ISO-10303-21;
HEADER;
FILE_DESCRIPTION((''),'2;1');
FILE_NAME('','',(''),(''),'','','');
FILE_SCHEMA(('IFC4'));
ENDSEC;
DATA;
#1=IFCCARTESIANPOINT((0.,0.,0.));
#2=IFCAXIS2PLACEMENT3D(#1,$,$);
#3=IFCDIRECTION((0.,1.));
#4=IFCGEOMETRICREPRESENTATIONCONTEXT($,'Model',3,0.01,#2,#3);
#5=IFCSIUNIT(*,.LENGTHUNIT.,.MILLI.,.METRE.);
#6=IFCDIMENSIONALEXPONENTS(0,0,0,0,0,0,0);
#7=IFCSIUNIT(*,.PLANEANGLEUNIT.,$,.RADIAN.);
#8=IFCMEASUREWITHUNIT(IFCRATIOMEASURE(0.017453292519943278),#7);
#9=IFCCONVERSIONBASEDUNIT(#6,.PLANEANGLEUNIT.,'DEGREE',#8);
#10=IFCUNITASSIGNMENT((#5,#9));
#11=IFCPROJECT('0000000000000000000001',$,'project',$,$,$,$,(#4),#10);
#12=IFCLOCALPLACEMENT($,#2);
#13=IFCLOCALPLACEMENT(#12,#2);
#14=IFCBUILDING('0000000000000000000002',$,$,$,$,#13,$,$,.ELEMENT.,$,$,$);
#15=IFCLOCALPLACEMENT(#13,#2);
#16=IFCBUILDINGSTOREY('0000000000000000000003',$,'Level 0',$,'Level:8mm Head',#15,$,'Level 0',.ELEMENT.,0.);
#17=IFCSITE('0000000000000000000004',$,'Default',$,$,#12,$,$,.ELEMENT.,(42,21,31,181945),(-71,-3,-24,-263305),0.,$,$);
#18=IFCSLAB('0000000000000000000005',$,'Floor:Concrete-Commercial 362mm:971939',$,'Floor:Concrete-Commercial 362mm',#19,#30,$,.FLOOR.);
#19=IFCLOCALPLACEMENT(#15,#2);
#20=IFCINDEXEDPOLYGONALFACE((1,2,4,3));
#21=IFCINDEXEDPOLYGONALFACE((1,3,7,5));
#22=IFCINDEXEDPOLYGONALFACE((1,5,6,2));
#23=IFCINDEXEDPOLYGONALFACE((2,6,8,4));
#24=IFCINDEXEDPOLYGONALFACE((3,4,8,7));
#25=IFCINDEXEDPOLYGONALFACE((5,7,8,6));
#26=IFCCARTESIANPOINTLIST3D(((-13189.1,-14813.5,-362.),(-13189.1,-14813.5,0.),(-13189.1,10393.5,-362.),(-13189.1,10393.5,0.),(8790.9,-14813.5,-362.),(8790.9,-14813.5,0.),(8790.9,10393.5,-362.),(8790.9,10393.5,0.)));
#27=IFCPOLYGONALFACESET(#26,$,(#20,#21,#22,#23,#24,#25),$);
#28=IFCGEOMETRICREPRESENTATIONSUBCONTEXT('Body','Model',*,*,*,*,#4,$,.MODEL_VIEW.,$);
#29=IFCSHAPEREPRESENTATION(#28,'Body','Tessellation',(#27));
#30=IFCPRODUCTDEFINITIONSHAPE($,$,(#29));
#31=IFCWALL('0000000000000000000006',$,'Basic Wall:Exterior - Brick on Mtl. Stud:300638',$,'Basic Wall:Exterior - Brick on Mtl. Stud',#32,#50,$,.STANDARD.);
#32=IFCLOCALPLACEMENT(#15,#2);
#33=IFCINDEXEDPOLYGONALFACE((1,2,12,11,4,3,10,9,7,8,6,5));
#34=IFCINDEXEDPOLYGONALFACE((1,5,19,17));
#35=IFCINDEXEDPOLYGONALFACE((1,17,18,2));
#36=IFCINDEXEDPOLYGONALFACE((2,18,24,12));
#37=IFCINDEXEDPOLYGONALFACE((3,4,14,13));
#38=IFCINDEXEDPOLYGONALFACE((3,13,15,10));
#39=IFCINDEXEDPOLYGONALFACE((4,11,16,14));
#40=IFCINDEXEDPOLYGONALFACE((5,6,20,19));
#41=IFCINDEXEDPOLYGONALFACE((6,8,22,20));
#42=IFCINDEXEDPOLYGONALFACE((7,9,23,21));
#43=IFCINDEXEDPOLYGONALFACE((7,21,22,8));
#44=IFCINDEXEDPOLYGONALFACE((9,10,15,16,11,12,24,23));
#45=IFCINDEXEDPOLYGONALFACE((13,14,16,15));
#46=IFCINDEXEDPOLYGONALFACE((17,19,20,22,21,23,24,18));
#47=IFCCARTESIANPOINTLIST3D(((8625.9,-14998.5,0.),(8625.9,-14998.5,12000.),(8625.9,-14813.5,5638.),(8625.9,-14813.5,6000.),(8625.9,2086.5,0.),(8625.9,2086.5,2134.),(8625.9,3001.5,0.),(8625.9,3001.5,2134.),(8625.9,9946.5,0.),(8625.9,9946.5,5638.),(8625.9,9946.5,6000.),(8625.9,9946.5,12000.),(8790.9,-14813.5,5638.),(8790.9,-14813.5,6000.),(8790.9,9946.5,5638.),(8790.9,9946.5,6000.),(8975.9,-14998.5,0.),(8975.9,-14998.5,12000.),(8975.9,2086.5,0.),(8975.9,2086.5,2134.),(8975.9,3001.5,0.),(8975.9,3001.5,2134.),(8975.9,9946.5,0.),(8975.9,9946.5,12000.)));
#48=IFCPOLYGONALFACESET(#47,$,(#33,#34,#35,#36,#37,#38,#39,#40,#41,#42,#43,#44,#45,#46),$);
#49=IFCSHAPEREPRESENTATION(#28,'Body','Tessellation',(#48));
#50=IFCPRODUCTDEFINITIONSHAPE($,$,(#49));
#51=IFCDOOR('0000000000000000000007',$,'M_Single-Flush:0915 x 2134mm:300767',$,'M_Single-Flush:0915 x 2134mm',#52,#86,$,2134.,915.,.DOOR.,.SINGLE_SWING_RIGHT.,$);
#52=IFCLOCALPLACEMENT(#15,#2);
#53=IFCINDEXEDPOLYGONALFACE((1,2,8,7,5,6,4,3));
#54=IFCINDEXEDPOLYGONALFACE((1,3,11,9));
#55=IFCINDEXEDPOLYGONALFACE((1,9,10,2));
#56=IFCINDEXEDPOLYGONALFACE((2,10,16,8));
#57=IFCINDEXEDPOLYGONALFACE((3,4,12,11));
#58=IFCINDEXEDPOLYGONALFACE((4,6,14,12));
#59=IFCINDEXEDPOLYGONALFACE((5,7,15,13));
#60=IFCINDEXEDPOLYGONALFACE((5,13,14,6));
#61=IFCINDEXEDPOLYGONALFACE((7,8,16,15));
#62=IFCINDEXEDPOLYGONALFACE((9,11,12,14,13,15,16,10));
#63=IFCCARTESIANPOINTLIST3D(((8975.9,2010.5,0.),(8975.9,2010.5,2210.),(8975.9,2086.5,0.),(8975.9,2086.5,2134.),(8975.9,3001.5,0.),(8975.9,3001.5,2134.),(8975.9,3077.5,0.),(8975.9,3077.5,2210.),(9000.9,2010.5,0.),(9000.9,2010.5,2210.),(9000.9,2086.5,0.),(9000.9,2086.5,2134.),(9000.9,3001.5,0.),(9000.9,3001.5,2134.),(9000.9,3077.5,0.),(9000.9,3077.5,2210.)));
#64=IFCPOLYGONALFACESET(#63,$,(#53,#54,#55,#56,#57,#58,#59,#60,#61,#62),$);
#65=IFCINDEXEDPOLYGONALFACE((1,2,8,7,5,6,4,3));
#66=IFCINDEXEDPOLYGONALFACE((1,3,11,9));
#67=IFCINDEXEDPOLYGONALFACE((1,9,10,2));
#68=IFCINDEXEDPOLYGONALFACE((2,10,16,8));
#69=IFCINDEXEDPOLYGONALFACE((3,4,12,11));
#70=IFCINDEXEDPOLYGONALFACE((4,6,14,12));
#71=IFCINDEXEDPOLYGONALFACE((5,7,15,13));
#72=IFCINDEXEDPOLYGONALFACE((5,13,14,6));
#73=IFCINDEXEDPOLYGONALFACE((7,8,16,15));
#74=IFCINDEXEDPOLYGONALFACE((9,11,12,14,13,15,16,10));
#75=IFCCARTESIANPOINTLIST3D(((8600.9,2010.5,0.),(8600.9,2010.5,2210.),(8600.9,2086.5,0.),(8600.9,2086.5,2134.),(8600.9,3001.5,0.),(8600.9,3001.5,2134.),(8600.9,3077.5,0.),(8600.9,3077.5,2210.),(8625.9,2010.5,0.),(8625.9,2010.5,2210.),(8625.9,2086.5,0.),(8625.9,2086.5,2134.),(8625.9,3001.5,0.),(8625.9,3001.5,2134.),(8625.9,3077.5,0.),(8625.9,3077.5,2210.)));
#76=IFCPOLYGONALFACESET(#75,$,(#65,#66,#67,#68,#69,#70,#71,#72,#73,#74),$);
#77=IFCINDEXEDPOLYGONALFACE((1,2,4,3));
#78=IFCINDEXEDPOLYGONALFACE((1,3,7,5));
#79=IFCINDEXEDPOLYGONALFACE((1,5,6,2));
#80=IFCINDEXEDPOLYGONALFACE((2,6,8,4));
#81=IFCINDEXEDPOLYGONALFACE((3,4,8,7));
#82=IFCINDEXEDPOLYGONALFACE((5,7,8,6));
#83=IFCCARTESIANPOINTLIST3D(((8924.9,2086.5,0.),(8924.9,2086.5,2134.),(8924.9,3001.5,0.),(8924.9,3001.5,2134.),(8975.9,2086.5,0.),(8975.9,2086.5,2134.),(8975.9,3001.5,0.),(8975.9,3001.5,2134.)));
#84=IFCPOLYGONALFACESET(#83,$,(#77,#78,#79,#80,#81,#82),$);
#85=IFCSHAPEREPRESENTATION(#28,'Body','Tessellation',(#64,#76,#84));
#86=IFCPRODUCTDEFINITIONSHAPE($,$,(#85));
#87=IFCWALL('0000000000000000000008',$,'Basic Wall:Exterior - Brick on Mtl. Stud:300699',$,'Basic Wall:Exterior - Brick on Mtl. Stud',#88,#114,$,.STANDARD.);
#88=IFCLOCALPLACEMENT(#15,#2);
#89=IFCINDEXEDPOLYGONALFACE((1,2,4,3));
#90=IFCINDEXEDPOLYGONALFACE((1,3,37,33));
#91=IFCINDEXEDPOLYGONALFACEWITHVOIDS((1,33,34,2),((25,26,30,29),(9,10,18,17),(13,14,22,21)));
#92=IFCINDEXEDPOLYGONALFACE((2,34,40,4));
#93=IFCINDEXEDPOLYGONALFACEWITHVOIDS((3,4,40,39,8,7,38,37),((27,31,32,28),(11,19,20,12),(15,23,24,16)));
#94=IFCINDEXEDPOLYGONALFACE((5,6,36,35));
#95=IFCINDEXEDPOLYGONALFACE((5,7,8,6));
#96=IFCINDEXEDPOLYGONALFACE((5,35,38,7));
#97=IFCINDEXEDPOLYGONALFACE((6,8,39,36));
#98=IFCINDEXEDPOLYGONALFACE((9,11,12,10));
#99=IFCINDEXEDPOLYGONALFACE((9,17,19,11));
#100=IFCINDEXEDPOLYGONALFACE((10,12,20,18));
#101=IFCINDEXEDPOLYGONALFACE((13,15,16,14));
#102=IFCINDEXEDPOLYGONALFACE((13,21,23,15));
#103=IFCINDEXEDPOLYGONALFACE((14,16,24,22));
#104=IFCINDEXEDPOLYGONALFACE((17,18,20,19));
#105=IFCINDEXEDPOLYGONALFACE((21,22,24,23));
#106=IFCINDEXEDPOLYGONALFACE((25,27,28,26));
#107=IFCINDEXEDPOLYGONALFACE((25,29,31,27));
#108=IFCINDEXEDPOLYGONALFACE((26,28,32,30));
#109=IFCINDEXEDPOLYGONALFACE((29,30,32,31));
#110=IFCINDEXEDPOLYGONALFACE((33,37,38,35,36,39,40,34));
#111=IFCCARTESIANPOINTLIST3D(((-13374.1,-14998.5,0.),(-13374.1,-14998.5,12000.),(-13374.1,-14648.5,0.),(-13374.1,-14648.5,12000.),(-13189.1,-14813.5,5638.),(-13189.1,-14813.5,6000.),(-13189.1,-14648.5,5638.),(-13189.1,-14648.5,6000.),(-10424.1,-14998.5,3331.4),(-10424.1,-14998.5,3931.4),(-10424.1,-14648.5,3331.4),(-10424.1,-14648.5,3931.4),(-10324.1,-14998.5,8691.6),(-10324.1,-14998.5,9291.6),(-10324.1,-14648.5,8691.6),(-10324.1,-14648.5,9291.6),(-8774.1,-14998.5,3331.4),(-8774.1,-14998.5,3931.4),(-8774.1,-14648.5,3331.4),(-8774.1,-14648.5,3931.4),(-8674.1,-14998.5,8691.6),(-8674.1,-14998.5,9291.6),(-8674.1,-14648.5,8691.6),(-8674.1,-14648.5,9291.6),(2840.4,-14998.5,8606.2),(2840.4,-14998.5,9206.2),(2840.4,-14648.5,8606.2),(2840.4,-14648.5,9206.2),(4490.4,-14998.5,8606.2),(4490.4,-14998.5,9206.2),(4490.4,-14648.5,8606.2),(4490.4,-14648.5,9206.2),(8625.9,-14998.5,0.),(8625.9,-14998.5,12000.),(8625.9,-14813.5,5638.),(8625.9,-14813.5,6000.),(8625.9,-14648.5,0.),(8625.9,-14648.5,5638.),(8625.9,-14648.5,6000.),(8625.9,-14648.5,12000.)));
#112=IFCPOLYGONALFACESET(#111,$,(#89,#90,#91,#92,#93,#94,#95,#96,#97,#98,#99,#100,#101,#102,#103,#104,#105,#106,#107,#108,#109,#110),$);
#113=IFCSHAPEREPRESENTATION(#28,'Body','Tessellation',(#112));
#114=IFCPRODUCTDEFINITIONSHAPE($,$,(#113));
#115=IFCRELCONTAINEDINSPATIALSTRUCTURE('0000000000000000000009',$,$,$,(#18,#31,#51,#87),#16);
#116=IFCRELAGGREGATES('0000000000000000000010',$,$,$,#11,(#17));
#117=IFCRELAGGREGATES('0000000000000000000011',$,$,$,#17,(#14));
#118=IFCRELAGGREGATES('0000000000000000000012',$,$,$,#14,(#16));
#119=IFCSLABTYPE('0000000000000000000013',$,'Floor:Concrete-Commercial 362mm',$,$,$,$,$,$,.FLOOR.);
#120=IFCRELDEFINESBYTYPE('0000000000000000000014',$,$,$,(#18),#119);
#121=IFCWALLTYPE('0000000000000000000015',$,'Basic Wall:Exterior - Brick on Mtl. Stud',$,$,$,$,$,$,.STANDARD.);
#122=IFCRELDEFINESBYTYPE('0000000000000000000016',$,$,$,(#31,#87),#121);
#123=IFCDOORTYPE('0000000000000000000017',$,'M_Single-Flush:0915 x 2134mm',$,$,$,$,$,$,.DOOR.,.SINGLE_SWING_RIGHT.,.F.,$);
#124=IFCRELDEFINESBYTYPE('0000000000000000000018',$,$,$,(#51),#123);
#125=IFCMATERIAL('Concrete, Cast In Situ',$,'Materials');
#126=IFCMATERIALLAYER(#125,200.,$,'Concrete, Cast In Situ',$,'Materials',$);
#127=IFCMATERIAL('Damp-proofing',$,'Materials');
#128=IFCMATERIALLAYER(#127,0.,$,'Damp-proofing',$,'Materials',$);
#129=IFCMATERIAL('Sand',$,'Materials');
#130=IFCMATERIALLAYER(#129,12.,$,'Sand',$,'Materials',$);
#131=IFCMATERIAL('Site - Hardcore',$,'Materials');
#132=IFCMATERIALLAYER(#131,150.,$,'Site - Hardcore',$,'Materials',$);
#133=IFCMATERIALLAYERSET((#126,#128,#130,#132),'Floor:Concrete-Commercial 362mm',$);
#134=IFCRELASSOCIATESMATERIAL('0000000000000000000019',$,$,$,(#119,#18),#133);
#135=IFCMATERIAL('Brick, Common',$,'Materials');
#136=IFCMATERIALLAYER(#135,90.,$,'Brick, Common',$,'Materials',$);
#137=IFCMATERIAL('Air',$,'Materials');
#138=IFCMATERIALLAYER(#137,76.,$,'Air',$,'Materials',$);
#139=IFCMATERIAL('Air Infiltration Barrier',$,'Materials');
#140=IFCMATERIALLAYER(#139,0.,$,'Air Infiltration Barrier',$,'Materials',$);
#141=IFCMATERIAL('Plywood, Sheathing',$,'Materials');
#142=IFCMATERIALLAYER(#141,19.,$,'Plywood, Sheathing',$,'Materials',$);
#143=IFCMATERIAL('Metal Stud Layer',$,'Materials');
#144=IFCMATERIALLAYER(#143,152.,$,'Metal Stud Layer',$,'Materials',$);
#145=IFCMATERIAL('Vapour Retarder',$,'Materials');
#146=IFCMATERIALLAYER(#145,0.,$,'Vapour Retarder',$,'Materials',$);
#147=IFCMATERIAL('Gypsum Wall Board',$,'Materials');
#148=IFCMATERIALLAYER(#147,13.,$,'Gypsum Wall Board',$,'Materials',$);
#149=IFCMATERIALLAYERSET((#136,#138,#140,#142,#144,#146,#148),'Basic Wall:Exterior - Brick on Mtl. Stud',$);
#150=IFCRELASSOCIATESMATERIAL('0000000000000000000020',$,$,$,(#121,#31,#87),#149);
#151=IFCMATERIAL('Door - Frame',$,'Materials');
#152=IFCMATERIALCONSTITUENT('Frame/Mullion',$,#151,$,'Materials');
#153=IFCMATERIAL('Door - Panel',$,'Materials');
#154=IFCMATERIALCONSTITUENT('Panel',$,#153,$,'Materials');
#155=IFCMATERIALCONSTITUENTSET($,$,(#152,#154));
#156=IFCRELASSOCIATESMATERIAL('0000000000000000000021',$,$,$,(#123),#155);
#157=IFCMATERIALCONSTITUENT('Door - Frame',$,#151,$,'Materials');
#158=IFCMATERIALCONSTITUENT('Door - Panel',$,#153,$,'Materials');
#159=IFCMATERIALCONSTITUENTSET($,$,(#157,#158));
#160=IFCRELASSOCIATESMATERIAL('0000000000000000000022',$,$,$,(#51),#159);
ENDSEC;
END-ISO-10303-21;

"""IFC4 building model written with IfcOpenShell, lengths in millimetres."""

from ifc_helpers import new_model, entity, si_unit, converted_unit, direction, frame, frame_2d, origin, place, context, subcontext, project, spatial, polyline, rectangle, outline, extrude, source, transform, mapped, material, layer, layer_set, layer_usage, constituent, constituent_set, type_object, type_shapes, element, fill, save


model = new_model("IFC4")

# Units and contexts
model_context = context("Model", 3, precision=0.01, world=origin(), true_north=direction((0.0, 1.0)))
body_context = subcontext(model_context, "Body", "Model", "MODEL_VIEW")
ifc_project = project(units=[si_unit("LENGTHUNIT", "METRE", prefix="MILLI"), converted_unit("PLANEANGLEUNIT", "DEGREE", entity("IfcRatioMeasure", 0.017453292519943278), si_unit("PLANEANGLEUNIT", "RADIAN"), dimensions=[0, 0, 0, 0, 0, 0, 0])], contexts=[model_context])

# Site, building, storey
site_placement = place(None, origin())
site = spatial("IfcSite", under=ifc_project, at=site_placement, Name="Default", CompositionType="ELEMENT", RefLatitude=(42, 21, 31, 181945), RefLongitude=(-71, -3, -24, -263305), RefElevation=0.0)
building_placement = place(site_placement, origin())
building = spatial("IfcBuilding", under=site, at=building_placement, CompositionType="ELEMENT")
storey_placement = place(building_placement, origin())
storey = spatial("IfcBuildingStorey", under=building, at=storey_placement, Name="Level 0", ObjectType="Level:8mm Head", LongName="Level 0", CompositionType="ELEMENT", Elevation=0.0)

# Slab
ifc_material_1 = material(Name="Concrete, Cast In Situ", Category="Materials")
ifc_layer_1 = layer(ifc_material_1, 200.0, Name="Concrete, Cast In Situ", Category="Materials")
ifc_material_2 = material(Name="Damp-proofing", Category="Materials")
ifc_layer_2 = layer(ifc_material_2, 0.0, Name="Damp-proofing", Category="Materials")
ifc_material_3 = material(Name="Sand", Category="Materials")
ifc_layer_3 = layer(ifc_material_3, 12.0, Name="Sand", Category="Materials")
ifc_material_4 = material(Name="Site - Hardcore", Category="Materials")
ifc_layer_4 = layer(ifc_material_4, 150.0, Name="Site - Hardcore", Category="Materials")
ifc_layer_set_1 = layer_set([ifc_layer_1, ifc_layer_2, ifc_layer_3, ifc_layer_4], Name="Floor:Concrete-Commercial 362mm")
ifc_layer_usage_1 = layer_usage(ifc_layer_set_1, "AXIS3", "POSITIVE", 0.0)
slab_type = type_object("IfcSlabType", Name="Floor:Concrete-Commercial 362mm", PredefinedType="FLOOR", material=ifc_layer_set_1)
slab_placement = place(storey_placement, origin())
element("IfcSlab", 1, at=slab_placement, inside=storey, type_object=slab_type, material=ifc_layer_usage_1, Name="Floor:Concrete-Commercial 362mm:971939", ObjectType="Floor:Concrete-Commercial 362mm", PredefinedType="FLOOR", context=body_context, shape_type="SweptSolid", body=[
    extrude(rectangle(XDim=25207.0, YDim=21980.0, at=frame_2d((0.0, 0.0), x_axis=(1.0, 0.0))), frame((-2199.1, -2210.0, 0.0), z_axis=(0.0, 0.0, -1.0), x_axis=(0.0, 1.0, 0.0)), (0.0, 0.0, 1.0), 362.0),
])

# Wall, openings, door
ifc_material_5 = material(Name="Brick, Common", Category="Materials")
ifc_layer_5 = layer(ifc_material_5, 90.0, Name="Brick, Common", Category="Materials")
ifc_material_6 = material(Name="Air", Category="Materials")
ifc_layer_6 = layer(ifc_material_6, 76.0, Name="Air", Category="Materials")
ifc_material_7 = material(Name="Air Infiltration Barrier", Category="Materials")
ifc_layer_7 = layer(ifc_material_7, 0.0, Name="Air Infiltration Barrier", Category="Materials")
ifc_material_8 = material(Name="Plywood, Sheathing", Category="Materials")
ifc_layer_8 = layer(ifc_material_8, 19.0, Name="Plywood, Sheathing", Category="Materials")
ifc_material_9 = material(Name="Metal Stud Layer", Category="Materials")
ifc_layer_9 = layer(ifc_material_9, 152.0, Name="Metal Stud Layer", Category="Materials")
ifc_material_10 = material(Name="Vapour Retarder", Category="Materials")
ifc_layer_10 = layer(ifc_material_10, 0.0, Name="Vapour Retarder", Category="Materials")
ifc_material_11 = material(Name="Gypsum Wall Board", Category="Materials")
ifc_layer_11 = layer(ifc_material_11, 13.0, Name="Gypsum Wall Board", Category="Materials")
ifc_layer_set_2 = layer_set([ifc_layer_5, ifc_layer_6, ifc_layer_7, ifc_layer_8, ifc_layer_9, ifc_layer_10, ifc_layer_11], Name="Basic Wall:Exterior - Brick on Mtl. Stud")
ifc_layer_usage_2 = layer_usage(ifc_layer_set_2, "AXIS2", "NEGATIVE", 175.0)
wall_type_1 = type_object("IfcWallType", Name="Basic Wall:Exterior - Brick on Mtl. Stud", PredefinedType="STANDARD", material=ifc_layer_set_2)
wall_1_placement = place(storey_placement, frame((8800.9, 9946.5, 0.0), z_axis=(0.0, 0.0, 1.0), x_axis=(0.0, -1.0, 0.0)))
wall_1 = element("IfcWall", 2, at=wall_1_placement, inside=storey, type_object=wall_type_1, material=ifc_layer_usage_2, Name="Basic Wall:Exterior - Brick on Mtl. Stud:300638", ObjectType="Basic Wall:Exterior - Brick on Mtl. Stud", PredefinedType="STANDARD", context=body_context, shape_type="SweptSolid", body=[
    extrude(rectangle(XDim=24945.0, YDim=350.0, at=frame_2d((12472.5, 0.0), x_axis=(-1.0, 0.0))), origin(), (0.0, 0.0, 1.0), 12000.0),
])
opening_1_placement = place(storey_placement, frame((8800.9, 9946.5, 0.0), z_axis=(0.0, 0.0, 1.0), x_axis=(0.0, -1.0, 0.0)))
element("IfcOpeningElement", 3, at=opening_1_placement, cuts=wall_1, PredefinedType="OPENING", context=body_context, shape_type="SweptSolid", body=[
    extrude(rectangle(XDim=165.0, YDim=24760.0, at=frame_2d((16.5, 2443.0), x_axis=(1.0, 0.0))), frame((14823.0, -109.0, 5638.0), z_axis=(0.0, 0.0, 1.0), x_axis=(0.0, 1.0, 0.0)), (0.0, 0.0, 1.0), 362.0),
])
opening_2_placement = place(wall_1_placement, frame((6945.0, -175.0, 0.0)))
opening_2 = element("IfcOpeningElement", 4, at=opening_2_placement, cuts=wall_1, PredefinedType="OPENING", context=body_context, shape_type="SweptSolid", body=[
    extrude(rectangle(XDim=915.0, YDim=2134.0, at=frame_2d((1067.0, 457.5), x_axis=(0.0, 1.0))), frame((0.0, 0.0, 0.0), z_axis=(0.0, 1.0, 0.0), x_axis=(0.0, 0.0, 1.0)), (0.0, 0.0, 1.0), 350.0),
])
ifc_material_12 = material(Name="Door - Frame", Category="Materials")
ifc_constituent_1 = constituent(ifc_material_12, Name="Door - Frame", Category="Materials")
ifc_material_13 = material(Name="Door - Panel", Category="Materials")
ifc_constituent_2 = constituent(ifc_material_13, Name="Door - Panel", Category="Materials")
ifc_constituent_set_1 = constituent_set(constituents=[ifc_constituent_1, ifc_constituent_2])
ifc_constituent_3 = constituent(ifc_material_12, Name="Frame/Mullion", Category="Materials")
ifc_constituent_4 = constituent(ifc_material_13, Name="Panel", Category="Materials")
ifc_constituent_set_2 = constituent_set(constituents=[ifc_constituent_3, ifc_constituent_4])
door_type_1 = type_object("IfcDoorType", Name="M_Single-Flush:0915 x 2134mm", OperationType="SINGLE_SWING_RIGHT", ParameterTakesPrecedence=False, PredefinedType="DOOR", material=ifc_constituent_set_2)
shared_shape_1 = source(origin(), body_context, "Body", "SweptSolid", [
    extrude(outline(polyline([(-533.5, -1124.0), (533.5, -1124.0), (533.5, 1086.0), (457.5, 1086.0), (457.5, -1048.0), (-457.5, -1048.0), (-457.5, 1086.0), (-533.5, 1086.0), (-533.5, -1124.0)])), frame((457.5, 350.0, 1086.0), z_axis=(0.0, 1.0, 0.0), x_axis=(1.0, 0.0, 0.0)), (0.0, 0.0, 1.0), 25.0),
    extrude(outline(polyline([(-1124.0, -533.5), (1086.0, -533.5), (1086.0, -457.5), (-1048.0, -457.5), (-1048.0, 457.5), (1086.0, 457.5), (1086.0, 533.5), (-1124.0, 533.5), (-1124.0, -533.5)])), frame((457.5, -25.0, 1086.0), z_axis=(0.0, 1.0, 0.0), x_axis=(0.0, 0.0, -1.0)), (0.0, 0.0, 1.0), 25.0),
    extrude(rectangle(XDim=51.0, YDim=915.0, at=frame_2d((0.0, 0.0), x_axis=(1.0, 0.0))), frame((457.5, 324.5, 0.0), z_axis=(0.0, 0.0, 1.0), x_axis=(0.0, 1.0, 0.0)), (0.0, 0.0, 1.0), 2134.0),
])
type_shapes(door_type_1, [shared_shape_1])
door_1_placement = place(opening_2_placement, origin())
door_1 = element("IfcDoor", 5, at=door_1_placement, inside=storey, type_object=door_type_1, material=ifc_constituent_set_1, Name="M_Single-Flush:0915 x 2134mm:300767", ObjectType="M_Single-Flush:0915 x 2134mm", OperationType="SINGLE_SWING_RIGHT", OverallHeight=2134.0, OverallWidth=915.0, PredefinedType="DOOR", context=body_context, shape_type="MappedRepresentation", body=[
    mapped(shared_shape_1, transform((0.0, 0.0, 0.0), scale=1.0)),
])
fill(opening_2, door_1)

# Wall, openings
wall_2_placement = place(storey_placement, frame((8625.9, -14823.5, 0.0), z_axis=(0.0, 0.0, 1.0), x_axis=(-1.0, 0.0, 0.0)))
wall_2 = element("IfcWall", 6, at=wall_2_placement, inside=storey, type_object=wall_type_1, material=ifc_layer_usage_2, Name="Basic Wall:Exterior - Brick on Mtl. Stud:300699", ObjectType="Basic Wall:Exterior - Brick on Mtl. Stud", PredefinedType="STANDARD", context=body_context, shape_type="SweptSolid", body=[
    extrude(rectangle(XDim=22000.0, YDim=350.0, at=frame_2d((11000.0, 0.0), x_axis=(-1.0, 0.0))), origin(), (0.0, 0.0, 1.0), 12000.0),
])
opening_3_placement = place(storey_placement, frame((8625.9, -14823.5, 0.0), z_axis=(0.0, 0.0, 1.0), x_axis=(-1.0, 0.0, 0.0)))
element("IfcOpeningElement", 7, at=opening_3_placement, cuts=wall_2, PredefinedType="OPENING", context=body_context, shape_type="SweptSolid", body=[
    extrude(rectangle(XDim=165.0, YDim=21815.0, at=frame_2d((35.4, 82.5), x_axis=(1.0, 0.0))), frame((10990.0, -127.9, 5638.0), z_axis=(0.0, 0.0, 1.0), x_axis=(0.0, 1.0, 0.0)), (0.0, 0.0, 1.0), 362.0),
])
opening_4_placement = place(wall_2_placement, frame((17300.0, -175.0, 8691.6)))
element("IfcOpeningElement", 8, at=opening_4_placement, cuts=wall_2, PredefinedType="OPENING", context=body_context, shape_type="SweptSolid", body=[
    extrude(rectangle(XDim=600.0, YDim=1650.0, at=frame_2d((300.0, 825.0), x_axis=(-1.0, 0.0))), frame((0.0, 0.0, 0.0), z_axis=(0.0, 1.0, 0.0), x_axis=(0.0, 0.0, 1.0)), (0.0, 0.0, 1.0), 350.0),
])
opening_5_placement = place(wall_2_placement, frame((4135.5, -175.0, 8606.2)))
element("IfcOpeningElement", 9, at=opening_5_placement, cuts=wall_2, PredefinedType="OPENING", context=body_context, shape_type="SweptSolid", body=[
    extrude(rectangle(XDim=600.0, YDim=1650.0, at=frame_2d((300.0, 825.0), x_axis=(-1.0, 0.0))), frame((0.0, 0.0, 0.0), z_axis=(0.0, 1.0, 0.0), x_axis=(0.0, 0.0, 1.0)), (0.0, 0.0, 1.0), 350.0),
])
opening_6_placement = place(wall_2_placement, frame((17400.0, -175.0, 3331.4)))
element("IfcOpeningElement", 10, at=opening_6_placement, cuts=wall_2, PredefinedType="OPENING", context=body_context, shape_type="SweptSolid", body=[
    extrude(rectangle(XDim=600.0, YDim=1650.0, at=frame_2d((300.0, 825.0), x_axis=(-1.0, 0.0))), frame((0.0, 0.0, 0.0), z_axis=(0.0, 1.0, 0.0), x_axis=(0.0, 0.0, 1.0)), (0.0, 0.0, 1.0), 350.0),
])

save(model, "model.ifc")
